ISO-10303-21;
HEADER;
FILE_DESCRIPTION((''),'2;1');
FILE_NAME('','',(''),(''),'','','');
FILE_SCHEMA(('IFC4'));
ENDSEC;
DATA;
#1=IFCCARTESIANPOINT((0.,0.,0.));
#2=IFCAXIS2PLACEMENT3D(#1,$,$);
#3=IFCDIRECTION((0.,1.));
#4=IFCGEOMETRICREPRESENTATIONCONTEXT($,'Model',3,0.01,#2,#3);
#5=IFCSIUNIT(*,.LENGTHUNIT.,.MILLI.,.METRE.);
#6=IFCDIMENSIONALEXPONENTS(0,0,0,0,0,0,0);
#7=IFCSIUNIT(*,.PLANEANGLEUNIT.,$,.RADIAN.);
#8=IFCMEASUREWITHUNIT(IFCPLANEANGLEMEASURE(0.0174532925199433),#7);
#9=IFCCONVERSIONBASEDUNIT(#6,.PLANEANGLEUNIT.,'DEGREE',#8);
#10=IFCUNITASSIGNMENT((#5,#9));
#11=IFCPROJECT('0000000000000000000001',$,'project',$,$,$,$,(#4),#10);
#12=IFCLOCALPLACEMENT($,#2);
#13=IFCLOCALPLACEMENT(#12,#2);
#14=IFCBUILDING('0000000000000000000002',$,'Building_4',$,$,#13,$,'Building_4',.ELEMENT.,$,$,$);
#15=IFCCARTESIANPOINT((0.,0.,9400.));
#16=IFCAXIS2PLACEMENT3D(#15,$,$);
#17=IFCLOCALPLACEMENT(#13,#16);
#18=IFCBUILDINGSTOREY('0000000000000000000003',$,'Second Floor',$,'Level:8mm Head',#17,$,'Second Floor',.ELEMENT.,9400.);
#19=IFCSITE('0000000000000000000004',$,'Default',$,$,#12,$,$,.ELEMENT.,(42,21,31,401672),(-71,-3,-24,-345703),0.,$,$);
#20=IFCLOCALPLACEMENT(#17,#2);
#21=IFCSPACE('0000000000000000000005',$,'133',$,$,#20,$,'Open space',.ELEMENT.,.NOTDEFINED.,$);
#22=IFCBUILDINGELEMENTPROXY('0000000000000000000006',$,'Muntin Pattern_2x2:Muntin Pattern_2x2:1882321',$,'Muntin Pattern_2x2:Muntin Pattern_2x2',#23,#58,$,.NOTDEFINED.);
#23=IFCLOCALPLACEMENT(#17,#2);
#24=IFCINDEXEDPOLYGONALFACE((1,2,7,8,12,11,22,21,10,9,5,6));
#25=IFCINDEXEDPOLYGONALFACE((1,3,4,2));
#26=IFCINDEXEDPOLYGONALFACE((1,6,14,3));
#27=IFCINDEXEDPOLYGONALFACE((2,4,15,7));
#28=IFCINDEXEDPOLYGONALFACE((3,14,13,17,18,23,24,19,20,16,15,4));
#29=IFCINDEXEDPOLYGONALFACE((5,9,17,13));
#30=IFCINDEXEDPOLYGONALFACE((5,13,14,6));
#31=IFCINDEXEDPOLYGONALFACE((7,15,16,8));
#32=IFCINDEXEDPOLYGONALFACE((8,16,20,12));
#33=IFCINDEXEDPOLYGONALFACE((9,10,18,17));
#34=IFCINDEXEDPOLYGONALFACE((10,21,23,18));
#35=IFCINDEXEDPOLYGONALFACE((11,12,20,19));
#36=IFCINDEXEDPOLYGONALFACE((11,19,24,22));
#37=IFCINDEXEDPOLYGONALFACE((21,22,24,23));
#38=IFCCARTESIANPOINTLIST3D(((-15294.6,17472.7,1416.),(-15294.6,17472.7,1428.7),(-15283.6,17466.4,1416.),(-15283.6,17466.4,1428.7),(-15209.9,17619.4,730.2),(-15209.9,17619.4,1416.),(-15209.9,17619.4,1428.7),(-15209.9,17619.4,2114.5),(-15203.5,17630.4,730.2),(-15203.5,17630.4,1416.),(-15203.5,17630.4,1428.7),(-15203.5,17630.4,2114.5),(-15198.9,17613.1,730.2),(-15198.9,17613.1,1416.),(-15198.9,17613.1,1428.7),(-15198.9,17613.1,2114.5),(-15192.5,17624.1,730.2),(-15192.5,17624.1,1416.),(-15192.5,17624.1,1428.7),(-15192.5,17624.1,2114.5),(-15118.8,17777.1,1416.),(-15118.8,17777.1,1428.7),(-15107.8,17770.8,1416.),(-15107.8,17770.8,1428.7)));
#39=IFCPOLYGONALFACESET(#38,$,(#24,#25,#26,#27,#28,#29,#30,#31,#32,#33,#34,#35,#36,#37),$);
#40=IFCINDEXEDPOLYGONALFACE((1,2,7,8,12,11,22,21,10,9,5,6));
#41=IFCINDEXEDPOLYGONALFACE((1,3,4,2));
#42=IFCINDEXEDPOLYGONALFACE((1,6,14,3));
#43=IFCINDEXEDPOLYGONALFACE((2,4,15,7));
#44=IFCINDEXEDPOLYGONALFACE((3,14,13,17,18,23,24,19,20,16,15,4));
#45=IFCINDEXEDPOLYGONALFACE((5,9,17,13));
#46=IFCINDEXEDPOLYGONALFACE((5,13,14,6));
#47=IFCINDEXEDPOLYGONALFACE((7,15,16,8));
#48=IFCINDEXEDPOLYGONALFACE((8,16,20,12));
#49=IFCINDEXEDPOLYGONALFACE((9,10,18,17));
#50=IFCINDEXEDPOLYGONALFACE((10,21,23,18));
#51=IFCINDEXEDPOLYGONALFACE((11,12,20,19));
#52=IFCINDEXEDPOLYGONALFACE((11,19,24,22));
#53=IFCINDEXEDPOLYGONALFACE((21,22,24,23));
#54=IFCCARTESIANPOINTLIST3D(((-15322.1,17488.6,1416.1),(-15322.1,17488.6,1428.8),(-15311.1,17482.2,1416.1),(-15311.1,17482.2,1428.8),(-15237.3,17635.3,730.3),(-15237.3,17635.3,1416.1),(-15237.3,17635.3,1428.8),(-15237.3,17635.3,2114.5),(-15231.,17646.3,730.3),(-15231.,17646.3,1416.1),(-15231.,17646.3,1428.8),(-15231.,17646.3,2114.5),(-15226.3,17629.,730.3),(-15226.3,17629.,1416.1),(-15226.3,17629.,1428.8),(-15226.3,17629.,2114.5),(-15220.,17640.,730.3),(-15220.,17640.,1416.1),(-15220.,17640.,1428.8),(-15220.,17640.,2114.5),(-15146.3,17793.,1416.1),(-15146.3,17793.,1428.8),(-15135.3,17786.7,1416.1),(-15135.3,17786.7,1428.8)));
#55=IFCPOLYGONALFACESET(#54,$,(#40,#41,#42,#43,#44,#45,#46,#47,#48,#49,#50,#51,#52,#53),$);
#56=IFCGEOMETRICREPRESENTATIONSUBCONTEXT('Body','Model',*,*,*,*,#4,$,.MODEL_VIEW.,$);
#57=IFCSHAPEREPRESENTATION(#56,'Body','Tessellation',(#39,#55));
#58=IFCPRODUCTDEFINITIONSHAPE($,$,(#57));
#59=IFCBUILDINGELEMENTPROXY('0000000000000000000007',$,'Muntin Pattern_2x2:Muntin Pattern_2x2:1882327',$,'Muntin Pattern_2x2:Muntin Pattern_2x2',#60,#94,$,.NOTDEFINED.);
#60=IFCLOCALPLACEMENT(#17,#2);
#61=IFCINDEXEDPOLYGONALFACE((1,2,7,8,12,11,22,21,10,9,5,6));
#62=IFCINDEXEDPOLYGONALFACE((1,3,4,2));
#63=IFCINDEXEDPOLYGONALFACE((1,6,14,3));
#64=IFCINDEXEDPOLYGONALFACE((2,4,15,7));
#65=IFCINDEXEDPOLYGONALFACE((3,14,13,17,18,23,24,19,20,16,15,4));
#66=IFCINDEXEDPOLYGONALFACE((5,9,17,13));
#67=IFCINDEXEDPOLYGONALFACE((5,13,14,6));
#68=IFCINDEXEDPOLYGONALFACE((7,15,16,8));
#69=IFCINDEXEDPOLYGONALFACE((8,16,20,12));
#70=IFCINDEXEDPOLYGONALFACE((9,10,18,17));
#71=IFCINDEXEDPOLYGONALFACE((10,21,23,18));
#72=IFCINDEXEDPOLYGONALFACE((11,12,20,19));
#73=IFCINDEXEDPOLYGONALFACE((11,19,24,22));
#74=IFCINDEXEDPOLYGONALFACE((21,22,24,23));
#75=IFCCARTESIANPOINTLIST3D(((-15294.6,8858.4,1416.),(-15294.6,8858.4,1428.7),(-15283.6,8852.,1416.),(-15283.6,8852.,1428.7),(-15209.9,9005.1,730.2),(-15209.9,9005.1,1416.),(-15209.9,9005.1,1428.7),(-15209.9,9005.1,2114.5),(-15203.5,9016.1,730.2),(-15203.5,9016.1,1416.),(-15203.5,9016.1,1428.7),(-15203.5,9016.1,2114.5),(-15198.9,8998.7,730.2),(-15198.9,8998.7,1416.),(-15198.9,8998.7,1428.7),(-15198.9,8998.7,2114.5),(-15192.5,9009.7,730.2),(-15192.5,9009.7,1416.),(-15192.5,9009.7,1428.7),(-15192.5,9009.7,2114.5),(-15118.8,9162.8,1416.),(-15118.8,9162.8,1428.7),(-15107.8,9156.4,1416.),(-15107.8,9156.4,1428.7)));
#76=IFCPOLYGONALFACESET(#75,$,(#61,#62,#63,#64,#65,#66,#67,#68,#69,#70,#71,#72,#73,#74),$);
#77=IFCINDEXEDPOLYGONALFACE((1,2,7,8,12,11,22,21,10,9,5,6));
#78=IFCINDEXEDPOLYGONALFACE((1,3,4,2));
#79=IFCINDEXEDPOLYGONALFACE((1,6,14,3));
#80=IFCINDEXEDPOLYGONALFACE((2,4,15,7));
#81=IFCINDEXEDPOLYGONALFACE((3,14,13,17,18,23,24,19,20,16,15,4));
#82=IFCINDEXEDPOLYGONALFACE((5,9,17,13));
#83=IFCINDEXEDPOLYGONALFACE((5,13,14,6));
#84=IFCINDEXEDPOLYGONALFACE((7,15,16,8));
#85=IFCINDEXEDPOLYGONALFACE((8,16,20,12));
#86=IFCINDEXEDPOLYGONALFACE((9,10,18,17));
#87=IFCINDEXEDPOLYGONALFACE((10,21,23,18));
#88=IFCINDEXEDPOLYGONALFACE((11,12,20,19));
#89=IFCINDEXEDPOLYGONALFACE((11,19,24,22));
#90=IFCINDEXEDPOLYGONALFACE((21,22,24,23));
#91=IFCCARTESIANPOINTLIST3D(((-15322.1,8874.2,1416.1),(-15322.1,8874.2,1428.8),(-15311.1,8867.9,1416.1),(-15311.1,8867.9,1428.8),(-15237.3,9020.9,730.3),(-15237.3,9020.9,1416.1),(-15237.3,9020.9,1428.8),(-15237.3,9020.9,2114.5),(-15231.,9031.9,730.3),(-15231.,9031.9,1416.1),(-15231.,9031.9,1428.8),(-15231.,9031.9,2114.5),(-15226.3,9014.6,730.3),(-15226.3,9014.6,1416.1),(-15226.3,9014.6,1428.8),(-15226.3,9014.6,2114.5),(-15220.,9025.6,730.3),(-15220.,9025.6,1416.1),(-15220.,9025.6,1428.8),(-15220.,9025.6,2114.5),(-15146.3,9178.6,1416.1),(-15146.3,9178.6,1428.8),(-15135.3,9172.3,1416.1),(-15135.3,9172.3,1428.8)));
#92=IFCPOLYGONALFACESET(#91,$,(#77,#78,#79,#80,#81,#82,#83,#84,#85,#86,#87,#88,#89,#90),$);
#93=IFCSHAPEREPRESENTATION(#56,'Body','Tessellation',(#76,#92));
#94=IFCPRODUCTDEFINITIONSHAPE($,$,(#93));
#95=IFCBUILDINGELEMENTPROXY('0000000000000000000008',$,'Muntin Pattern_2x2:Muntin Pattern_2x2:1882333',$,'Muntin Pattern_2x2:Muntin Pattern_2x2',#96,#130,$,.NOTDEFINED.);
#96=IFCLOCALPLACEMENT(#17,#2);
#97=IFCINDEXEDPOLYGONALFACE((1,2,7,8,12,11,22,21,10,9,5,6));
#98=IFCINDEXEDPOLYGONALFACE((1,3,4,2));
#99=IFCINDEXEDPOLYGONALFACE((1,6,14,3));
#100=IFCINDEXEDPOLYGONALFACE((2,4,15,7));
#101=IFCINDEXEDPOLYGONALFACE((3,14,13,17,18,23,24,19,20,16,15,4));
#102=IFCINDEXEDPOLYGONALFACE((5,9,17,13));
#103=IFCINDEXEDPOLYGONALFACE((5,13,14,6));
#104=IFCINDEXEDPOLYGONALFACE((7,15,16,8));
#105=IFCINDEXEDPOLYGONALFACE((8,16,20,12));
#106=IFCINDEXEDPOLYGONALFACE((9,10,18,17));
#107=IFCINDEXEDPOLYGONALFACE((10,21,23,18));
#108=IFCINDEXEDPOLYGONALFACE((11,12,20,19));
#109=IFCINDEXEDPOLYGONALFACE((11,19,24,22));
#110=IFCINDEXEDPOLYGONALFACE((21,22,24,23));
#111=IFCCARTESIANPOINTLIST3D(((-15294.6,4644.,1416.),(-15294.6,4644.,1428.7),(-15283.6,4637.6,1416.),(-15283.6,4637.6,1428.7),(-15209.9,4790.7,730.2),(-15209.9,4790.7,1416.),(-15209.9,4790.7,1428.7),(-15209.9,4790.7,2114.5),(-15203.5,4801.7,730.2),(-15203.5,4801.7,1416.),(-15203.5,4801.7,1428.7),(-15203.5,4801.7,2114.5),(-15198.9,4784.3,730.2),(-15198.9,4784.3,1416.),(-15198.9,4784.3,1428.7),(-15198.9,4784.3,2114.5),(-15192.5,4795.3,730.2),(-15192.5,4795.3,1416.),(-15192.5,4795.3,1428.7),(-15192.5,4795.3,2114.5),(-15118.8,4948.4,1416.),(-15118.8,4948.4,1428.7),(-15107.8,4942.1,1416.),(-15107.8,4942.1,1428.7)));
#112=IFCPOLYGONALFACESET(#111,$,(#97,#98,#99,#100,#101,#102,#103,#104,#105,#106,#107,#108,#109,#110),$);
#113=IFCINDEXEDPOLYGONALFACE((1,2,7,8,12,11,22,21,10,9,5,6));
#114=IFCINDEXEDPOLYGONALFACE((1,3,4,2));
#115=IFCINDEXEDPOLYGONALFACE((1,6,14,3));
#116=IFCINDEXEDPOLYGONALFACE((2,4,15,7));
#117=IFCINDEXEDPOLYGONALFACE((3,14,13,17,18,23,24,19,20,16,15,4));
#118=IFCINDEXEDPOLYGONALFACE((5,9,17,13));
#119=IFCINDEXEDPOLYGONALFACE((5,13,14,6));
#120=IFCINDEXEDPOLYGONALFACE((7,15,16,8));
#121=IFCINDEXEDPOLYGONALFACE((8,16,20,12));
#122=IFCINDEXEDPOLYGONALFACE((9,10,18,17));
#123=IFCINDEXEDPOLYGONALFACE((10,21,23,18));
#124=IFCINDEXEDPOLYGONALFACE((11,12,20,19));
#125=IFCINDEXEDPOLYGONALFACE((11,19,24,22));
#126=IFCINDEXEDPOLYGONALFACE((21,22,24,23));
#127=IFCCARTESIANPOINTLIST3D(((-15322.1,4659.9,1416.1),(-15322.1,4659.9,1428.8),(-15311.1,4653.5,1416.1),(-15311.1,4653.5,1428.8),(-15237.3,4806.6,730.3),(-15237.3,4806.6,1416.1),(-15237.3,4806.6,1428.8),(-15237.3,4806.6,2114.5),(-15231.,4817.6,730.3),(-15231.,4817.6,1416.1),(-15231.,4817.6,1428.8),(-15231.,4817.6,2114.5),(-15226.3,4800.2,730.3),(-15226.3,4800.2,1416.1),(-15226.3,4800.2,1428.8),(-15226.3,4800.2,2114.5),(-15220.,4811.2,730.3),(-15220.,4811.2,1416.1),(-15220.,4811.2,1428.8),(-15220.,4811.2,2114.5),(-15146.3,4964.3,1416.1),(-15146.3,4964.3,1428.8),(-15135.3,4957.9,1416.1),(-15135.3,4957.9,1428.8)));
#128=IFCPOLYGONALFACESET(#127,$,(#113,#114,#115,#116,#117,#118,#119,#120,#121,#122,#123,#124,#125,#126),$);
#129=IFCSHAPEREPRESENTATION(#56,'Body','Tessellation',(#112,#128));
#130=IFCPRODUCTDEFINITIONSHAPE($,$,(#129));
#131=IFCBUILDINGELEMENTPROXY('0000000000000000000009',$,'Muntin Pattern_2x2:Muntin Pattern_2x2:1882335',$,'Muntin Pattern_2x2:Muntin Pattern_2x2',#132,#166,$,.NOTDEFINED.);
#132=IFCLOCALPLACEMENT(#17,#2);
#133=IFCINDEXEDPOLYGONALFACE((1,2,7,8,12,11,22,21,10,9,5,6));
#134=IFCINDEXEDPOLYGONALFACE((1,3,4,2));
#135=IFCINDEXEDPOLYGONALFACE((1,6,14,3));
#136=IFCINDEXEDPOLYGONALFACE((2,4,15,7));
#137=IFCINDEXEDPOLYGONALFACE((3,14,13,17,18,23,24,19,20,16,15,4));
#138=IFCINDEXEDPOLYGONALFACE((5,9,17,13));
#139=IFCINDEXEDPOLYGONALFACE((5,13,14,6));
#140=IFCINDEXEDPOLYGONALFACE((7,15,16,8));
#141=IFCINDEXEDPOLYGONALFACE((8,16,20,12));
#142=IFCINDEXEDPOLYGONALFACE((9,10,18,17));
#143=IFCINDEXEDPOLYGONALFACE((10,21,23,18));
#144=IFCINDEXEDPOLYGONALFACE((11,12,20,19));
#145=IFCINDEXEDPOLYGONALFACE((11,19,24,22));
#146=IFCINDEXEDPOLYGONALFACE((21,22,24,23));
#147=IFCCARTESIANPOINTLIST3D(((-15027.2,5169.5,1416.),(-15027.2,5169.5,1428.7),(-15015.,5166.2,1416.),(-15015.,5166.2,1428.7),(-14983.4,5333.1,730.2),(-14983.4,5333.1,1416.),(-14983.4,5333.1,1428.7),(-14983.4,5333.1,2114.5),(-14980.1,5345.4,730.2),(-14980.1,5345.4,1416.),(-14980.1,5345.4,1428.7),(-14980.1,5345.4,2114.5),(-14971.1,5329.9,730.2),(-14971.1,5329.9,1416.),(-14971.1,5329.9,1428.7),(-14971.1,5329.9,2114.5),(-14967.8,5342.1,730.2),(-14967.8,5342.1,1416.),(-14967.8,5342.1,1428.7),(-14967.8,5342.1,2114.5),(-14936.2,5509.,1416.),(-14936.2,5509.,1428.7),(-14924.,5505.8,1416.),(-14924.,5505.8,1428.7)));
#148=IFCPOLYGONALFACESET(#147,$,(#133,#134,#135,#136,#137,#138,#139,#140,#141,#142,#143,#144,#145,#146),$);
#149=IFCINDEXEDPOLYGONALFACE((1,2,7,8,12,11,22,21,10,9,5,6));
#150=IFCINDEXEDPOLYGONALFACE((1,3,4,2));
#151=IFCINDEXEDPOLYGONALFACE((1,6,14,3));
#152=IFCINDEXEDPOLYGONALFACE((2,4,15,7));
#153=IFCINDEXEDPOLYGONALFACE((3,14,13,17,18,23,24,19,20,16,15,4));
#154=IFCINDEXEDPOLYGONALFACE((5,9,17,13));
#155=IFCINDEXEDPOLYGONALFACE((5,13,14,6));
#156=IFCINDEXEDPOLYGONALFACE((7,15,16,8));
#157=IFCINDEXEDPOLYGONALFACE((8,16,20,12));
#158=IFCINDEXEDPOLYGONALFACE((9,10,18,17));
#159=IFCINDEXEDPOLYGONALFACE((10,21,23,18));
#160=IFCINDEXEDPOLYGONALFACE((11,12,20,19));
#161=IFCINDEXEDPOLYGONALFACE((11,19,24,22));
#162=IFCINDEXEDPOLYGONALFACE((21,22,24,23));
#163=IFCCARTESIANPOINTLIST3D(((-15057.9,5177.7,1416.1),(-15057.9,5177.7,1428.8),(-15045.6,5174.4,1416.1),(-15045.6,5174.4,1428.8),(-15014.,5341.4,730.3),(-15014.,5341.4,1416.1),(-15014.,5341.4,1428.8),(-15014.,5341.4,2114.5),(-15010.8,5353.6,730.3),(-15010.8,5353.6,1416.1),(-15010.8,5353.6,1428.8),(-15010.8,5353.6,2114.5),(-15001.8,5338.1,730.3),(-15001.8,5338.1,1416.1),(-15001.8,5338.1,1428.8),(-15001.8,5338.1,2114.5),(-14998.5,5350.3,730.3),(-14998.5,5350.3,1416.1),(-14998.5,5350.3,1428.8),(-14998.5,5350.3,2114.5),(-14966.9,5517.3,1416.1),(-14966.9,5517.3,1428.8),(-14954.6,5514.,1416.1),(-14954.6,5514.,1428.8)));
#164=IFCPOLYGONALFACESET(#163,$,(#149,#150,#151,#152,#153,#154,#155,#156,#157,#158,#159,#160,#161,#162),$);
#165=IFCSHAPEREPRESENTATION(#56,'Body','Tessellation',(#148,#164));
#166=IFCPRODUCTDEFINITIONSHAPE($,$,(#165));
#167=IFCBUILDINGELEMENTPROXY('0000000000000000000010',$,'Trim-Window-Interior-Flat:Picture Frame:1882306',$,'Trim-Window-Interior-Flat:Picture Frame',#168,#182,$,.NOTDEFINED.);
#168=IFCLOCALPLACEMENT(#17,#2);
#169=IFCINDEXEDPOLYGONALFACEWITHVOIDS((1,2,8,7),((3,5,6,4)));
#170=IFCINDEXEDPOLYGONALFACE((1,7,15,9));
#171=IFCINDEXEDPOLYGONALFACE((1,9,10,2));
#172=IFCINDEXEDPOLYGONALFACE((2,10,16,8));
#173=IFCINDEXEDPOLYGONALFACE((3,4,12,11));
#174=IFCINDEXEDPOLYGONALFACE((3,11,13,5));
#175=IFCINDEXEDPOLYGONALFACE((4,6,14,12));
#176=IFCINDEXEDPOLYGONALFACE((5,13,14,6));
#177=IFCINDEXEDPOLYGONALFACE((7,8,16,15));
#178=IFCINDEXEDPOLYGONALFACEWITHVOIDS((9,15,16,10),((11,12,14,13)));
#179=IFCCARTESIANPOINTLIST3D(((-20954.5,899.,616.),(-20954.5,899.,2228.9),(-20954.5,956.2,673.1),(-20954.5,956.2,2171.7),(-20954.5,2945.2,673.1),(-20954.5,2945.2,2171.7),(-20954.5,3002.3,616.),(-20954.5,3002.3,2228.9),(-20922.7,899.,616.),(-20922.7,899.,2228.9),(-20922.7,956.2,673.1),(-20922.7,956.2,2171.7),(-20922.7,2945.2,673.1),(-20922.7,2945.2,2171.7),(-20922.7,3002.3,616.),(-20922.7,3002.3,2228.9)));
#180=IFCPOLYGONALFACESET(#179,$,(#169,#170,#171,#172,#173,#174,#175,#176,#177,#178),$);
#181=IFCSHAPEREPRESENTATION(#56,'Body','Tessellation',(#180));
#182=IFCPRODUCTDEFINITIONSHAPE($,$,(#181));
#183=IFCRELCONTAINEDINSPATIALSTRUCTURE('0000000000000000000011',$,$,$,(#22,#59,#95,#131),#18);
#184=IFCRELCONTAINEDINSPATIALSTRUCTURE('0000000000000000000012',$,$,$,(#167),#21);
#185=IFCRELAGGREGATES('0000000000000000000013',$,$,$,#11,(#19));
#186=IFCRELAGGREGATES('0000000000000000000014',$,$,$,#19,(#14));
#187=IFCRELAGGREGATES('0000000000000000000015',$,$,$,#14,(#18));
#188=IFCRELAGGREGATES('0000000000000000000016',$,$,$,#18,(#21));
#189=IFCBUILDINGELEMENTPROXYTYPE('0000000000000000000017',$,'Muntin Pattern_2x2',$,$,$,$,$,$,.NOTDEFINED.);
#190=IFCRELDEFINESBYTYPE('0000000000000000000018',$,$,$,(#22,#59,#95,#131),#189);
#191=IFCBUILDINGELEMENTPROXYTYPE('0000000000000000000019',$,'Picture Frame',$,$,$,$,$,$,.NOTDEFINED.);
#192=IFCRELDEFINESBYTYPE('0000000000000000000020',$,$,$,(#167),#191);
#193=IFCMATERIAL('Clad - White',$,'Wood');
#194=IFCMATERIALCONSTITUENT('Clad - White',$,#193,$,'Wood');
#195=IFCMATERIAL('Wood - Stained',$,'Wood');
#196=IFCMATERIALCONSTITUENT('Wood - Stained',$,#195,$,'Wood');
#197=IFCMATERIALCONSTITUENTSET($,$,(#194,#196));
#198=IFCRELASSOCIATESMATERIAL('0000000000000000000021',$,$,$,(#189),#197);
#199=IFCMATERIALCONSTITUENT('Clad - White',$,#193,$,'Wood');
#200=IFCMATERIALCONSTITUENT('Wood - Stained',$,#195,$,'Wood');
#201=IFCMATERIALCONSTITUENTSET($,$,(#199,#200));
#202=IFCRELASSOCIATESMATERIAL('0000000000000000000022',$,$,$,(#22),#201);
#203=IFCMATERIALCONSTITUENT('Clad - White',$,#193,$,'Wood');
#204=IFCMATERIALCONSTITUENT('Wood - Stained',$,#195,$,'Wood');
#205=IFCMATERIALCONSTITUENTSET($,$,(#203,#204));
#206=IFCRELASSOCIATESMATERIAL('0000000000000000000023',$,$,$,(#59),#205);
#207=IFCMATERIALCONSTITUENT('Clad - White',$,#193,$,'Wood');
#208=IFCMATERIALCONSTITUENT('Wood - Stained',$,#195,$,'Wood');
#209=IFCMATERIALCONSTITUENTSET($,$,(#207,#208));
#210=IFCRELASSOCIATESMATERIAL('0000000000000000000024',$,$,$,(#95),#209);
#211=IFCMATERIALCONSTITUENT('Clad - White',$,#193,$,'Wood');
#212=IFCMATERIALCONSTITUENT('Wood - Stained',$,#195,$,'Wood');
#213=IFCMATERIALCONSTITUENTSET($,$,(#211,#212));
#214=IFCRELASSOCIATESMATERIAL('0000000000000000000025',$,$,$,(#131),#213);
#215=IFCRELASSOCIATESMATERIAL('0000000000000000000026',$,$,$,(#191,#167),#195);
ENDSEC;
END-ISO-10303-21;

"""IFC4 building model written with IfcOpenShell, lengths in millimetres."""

from ifc_helpers import new_model, entity, si_unit, converted_unit, direction, frame, origin, place, context, subcontext, project, spatial, indexed_curve, outline, extrude, source, transform, mapped, material, constituent, constituent_set, type_object, type_shapes, element, save


model = new_model("IFC4")

# Units and contexts
model_context = context("Model", 3, precision=0.01, world=origin(), true_north=direction((0.0, 1.0)))
body_context = subcontext(model_context, "Body", "Model", "MODEL_VIEW")
ifc_project = project(units=[si_unit("LENGTHUNIT", "METRE", prefix="MILLI"), converted_unit("PLANEANGLEUNIT", "DEGREE", entity("IfcPlaneAngleMeasure", 0.0174532925199433), si_unit("PLANEANGLEUNIT", "RADIAN"), dimensions=[0, 0, 0, 0, 0, 0, 0])], contexts=[model_context])

# Site, building, storey
site_placement = place(None, origin())
site = spatial("IfcSite", under=ifc_project, at=site_placement, Name="Default", CompositionType="ELEMENT", RefLatitude=(42, 21, 31, 401672), RefLongitude=(-71, -3, -24, -345703), RefElevation=0.0)
building_placement = place(site_placement, origin())
building = spatial("IfcBuilding", under=site, at=building_placement, Name="Building_4", LongName="Building_4", CompositionType="ELEMENT")
storey_placement = place(building_placement, frame((0.0, 0.0, 9400.0)))
storey = spatial("IfcBuildingStorey", under=building, at=storey_placement, Name="Second Floor", ObjectType="Level:8mm Head", LongName="Second Floor", CompositionType="ELEMENT", Elevation=9400.0)

# Building element proxies
ifc_material_1 = material(Name="Clad - White", Category="Wood")
ifc_material_2 = material(Name="Wood - Stained", Category="Wood")
ifc_constituent_1 = constituent(ifc_material_1, Name="Clad - White", Category="Wood")
ifc_constituent_2 = constituent(ifc_material_2, Name="Wood - Stained", Category="Wood")
ifc_constituent_set_1 = constituent_set(constituents=[ifc_constituent_1, ifc_constituent_2])
building_element_proxy_type_1 = type_object("IfcBuildingElementProxyType", Name="Muntin Pattern_2x2", PredefinedType="NOTDEFINED", material=ifc_constituent_set_1)
shared_shape_1 = source(origin(), body_context, "Body", "SweptSolid", [
    extrude(outline(indexed_curve([(6.4, -6.4), (692.1, -6.4), (692.1, 6.3), (6.4, 6.3), (6.4, 175.8), (-6.3, 175.8), (-6.3, 6.3), (-692.2, 6.3), (-692.2, -6.4), (-6.3, -6.4), (-6.3, -175.8), (6.4, -175.8), (6.4, -6.4)], self_intersect=False)), frame((0.0, -22.2, 692.1), z_axis=(0.0, 1.0, 0.0), x_axis=(0.0, 0.0, 1.0)), (0.0, 0.0, 1.0), 12.7),
    extrude(outline(indexed_curve([(6.4, -6.4), (692.1, -6.4), (692.1, 6.3), (6.4, 6.3), (6.4, 175.8), (-6.3, 175.8), (-6.3, 6.3), (-692.1, 6.3), (-692.1, -6.4), (-6.3, -6.4), (-6.3, -175.8), (6.4, -175.8), (6.4, -6.4)], self_intersect=False)), frame((0.0, 9.5, 692.1), z_axis=(0.0, 1.0, 0.0), x_axis=(0.0, 0.0, 1.0)), (0.0, 0.0, 1.0), 12.7),
])
type_shapes(building_element_proxy_type_1, [shared_shape_1])
ifc_constituent_3 = constituent(ifc_material_1, Name="Clad - White", Category="Wood")
ifc_constituent_4 = constituent(ifc_material_2, Name="Wood - Stained", Category="Wood")
ifc_constituent_set_2 = constituent_set(constituents=[ifc_constituent_3, ifc_constituent_4])
proxy_1_placement = place(storey_placement, frame((-15214.9, 17629.7, 730.3), z_axis=(0.0, 0.0, 1.0), x_axis=(0.5, 0.866025, 0.0)))
element("IfcBuildingElementProxy", 1, at=proxy_1_placement, inside=storey, type_object=building_element_proxy_type_1, material=ifc_constituent_set_2, Name="Muntin Pattern_2x2:Muntin Pattern_2x2:1882321", ObjectType="Muntin Pattern_2x2:Muntin Pattern_2x2", PredefinedType="NOTDEFINED", context=body_context, shape_type="MappedRepresentation", body=[
    mapped(shared_shape_1, transform((0.0, 0.0, 0.0), scale=1.0)),
])
ifc_constituent_5 = constituent(ifc_material_1, Name="Clad - White", Category="Wood")
ifc_constituent_6 = constituent(ifc_material_2, Name="Wood - Stained", Category="Wood")
ifc_constituent_set_3 = constituent_set(constituents=[ifc_constituent_5, ifc_constituent_6])
proxy_2_placement = place(storey_placement, frame((-15214.9, 9015.3, 730.3), z_axis=(0.0, 0.0, 1.0), x_axis=(0.5, 0.866025, 0.0)))
element("IfcBuildingElementProxy", 2, at=proxy_2_placement, inside=storey, type_object=building_element_proxy_type_1, material=ifc_constituent_set_3, Name="Muntin Pattern_2x2:Muntin Pattern_2x2:1882327", ObjectType="Muntin Pattern_2x2:Muntin Pattern_2x2", PredefinedType="NOTDEFINED", context=body_context, shape_type="MappedRepresentation", body=[
    mapped(shared_shape_1, transform((0.0, 0.0, 0.0), scale=1.0)),
])
ifc_constituent_7 = constituent(ifc_material_1, Name="Clad - White", Category="Wood")
ifc_constituent_8 = constituent(ifc_material_2, Name="Wood - Stained", Category="Wood")
ifc_constituent_set_4 = constituent_set(constituents=[ifc_constituent_7, ifc_constituent_8])
proxy_3_placement = place(storey_placement, frame((-15214.9, 4801.0, 730.3), z_axis=(0.0, 0.0, 1.0), x_axis=(0.5, 0.866025, 0.0)))
element("IfcBuildingElementProxy", 3, at=proxy_3_placement, inside=storey, type_object=building_element_proxy_type_1, material=ifc_constituent_set_4, Name="Muntin Pattern_2x2:Muntin Pattern_2x2:1882333", ObjectType="Muntin Pattern_2x2:Muntin Pattern_2x2", PredefinedType="NOTDEFINED", context=body_context, shape_type="MappedRepresentation", body=[
    mapped(shared_shape_1, transform((0.0, 0.0, 0.0), scale=1.0)),
])
ifc_constituent_9 = constituent(ifc_material_1, Name="Clad - White", Category="Wood")
ifc_constituent_10 = constituent(ifc_material_2, Name="Wood - Stained", Category="Wood")
ifc_constituent_set_5 = constituent_set(constituents=[ifc_constituent_9, ifc_constituent_10])
proxy_4_placement = place(storey_placement, frame((-14990.9, 5341.7, 730.3), z_axis=(0.0, 0.0, 1.0), x_axis=(0.258819, 0.965926, 0.0)))
element("IfcBuildingElementProxy", 4, at=proxy_4_placement, inside=storey, type_object=building_element_proxy_type_1, material=ifc_constituent_set_5, Name="Muntin Pattern_2x2:Muntin Pattern_2x2:1882335", ObjectType="Muntin Pattern_2x2:Muntin Pattern_2x2", PredefinedType="NOTDEFINED", context=body_context, shape_type="MappedRepresentation", body=[
    mapped(shared_shape_1, transform((0.0, 0.0, 0.0), scale=1.0)),
])

# Shared definitions
space_placement = place(storey_placement, origin())
space = spatial("IfcSpace", under=storey, at=space_placement, Name="133", LongName="Open space", CompositionType="ELEMENT", PredefinedType="NOTDEFINED")

# Building element proxy
building_element_proxy_type_2 = type_object("IfcBuildingElementProxyType", Name="Picture Frame", PredefinedType="NOTDEFINED", material=ifc_material_2)
shared_shape_2 = source(origin(), body_context, "Body", "SweptSolid", [
    extrude(outline(indexed_curve([(-1051.6, -806.4), (1051.6, -806.4), (1051.6, 806.4), (-1051.6, 806.4), (-1051.6, -806.4)], self_intersect=False), holes=[indexed_curve([(-994.5, -749.3), (-994.5, 749.3), (994.5, 749.3), (994.5, -749.3), (-994.5, -749.3)], self_intersect=False)]), frame((0.0, -762.0, 0.0), z_axis=(0.0, 0.0, 1.0), x_axis=(-1.0, 0.0, 0.0)), (0.0, 0.0, 1.0), 31.8),
])
type_shapes(building_element_proxy_type_2, [shared_shape_2])
for number, where, z_axis, x_axis, name in (
    (5, (-20954.5, 1950.7, 2184.4), (1.0, 0.0, 0.0), (0.0, 1.0, 0.0), "Trim-Window-Interior-Flat:Picture Frame:1882306"),
):
    element("IfcBuildingElementProxy", number, at=place(space_placement, frame(where, z_axis=z_axis, x_axis=x_axis)), inside=space, type_object=building_element_proxy_type_2, material=ifc_material_2, Name=name, ObjectType="Trim-Window-Interior-Flat:Picture Frame", PredefinedType="NOTDEFINED", context=body_context, shape_type="MappedRepresentation", body=[
        mapped(shared_shape_2, transform((0.0, 0.0, 0.0), scale=1.0)),
    ])

save(model, "model.ifc")
